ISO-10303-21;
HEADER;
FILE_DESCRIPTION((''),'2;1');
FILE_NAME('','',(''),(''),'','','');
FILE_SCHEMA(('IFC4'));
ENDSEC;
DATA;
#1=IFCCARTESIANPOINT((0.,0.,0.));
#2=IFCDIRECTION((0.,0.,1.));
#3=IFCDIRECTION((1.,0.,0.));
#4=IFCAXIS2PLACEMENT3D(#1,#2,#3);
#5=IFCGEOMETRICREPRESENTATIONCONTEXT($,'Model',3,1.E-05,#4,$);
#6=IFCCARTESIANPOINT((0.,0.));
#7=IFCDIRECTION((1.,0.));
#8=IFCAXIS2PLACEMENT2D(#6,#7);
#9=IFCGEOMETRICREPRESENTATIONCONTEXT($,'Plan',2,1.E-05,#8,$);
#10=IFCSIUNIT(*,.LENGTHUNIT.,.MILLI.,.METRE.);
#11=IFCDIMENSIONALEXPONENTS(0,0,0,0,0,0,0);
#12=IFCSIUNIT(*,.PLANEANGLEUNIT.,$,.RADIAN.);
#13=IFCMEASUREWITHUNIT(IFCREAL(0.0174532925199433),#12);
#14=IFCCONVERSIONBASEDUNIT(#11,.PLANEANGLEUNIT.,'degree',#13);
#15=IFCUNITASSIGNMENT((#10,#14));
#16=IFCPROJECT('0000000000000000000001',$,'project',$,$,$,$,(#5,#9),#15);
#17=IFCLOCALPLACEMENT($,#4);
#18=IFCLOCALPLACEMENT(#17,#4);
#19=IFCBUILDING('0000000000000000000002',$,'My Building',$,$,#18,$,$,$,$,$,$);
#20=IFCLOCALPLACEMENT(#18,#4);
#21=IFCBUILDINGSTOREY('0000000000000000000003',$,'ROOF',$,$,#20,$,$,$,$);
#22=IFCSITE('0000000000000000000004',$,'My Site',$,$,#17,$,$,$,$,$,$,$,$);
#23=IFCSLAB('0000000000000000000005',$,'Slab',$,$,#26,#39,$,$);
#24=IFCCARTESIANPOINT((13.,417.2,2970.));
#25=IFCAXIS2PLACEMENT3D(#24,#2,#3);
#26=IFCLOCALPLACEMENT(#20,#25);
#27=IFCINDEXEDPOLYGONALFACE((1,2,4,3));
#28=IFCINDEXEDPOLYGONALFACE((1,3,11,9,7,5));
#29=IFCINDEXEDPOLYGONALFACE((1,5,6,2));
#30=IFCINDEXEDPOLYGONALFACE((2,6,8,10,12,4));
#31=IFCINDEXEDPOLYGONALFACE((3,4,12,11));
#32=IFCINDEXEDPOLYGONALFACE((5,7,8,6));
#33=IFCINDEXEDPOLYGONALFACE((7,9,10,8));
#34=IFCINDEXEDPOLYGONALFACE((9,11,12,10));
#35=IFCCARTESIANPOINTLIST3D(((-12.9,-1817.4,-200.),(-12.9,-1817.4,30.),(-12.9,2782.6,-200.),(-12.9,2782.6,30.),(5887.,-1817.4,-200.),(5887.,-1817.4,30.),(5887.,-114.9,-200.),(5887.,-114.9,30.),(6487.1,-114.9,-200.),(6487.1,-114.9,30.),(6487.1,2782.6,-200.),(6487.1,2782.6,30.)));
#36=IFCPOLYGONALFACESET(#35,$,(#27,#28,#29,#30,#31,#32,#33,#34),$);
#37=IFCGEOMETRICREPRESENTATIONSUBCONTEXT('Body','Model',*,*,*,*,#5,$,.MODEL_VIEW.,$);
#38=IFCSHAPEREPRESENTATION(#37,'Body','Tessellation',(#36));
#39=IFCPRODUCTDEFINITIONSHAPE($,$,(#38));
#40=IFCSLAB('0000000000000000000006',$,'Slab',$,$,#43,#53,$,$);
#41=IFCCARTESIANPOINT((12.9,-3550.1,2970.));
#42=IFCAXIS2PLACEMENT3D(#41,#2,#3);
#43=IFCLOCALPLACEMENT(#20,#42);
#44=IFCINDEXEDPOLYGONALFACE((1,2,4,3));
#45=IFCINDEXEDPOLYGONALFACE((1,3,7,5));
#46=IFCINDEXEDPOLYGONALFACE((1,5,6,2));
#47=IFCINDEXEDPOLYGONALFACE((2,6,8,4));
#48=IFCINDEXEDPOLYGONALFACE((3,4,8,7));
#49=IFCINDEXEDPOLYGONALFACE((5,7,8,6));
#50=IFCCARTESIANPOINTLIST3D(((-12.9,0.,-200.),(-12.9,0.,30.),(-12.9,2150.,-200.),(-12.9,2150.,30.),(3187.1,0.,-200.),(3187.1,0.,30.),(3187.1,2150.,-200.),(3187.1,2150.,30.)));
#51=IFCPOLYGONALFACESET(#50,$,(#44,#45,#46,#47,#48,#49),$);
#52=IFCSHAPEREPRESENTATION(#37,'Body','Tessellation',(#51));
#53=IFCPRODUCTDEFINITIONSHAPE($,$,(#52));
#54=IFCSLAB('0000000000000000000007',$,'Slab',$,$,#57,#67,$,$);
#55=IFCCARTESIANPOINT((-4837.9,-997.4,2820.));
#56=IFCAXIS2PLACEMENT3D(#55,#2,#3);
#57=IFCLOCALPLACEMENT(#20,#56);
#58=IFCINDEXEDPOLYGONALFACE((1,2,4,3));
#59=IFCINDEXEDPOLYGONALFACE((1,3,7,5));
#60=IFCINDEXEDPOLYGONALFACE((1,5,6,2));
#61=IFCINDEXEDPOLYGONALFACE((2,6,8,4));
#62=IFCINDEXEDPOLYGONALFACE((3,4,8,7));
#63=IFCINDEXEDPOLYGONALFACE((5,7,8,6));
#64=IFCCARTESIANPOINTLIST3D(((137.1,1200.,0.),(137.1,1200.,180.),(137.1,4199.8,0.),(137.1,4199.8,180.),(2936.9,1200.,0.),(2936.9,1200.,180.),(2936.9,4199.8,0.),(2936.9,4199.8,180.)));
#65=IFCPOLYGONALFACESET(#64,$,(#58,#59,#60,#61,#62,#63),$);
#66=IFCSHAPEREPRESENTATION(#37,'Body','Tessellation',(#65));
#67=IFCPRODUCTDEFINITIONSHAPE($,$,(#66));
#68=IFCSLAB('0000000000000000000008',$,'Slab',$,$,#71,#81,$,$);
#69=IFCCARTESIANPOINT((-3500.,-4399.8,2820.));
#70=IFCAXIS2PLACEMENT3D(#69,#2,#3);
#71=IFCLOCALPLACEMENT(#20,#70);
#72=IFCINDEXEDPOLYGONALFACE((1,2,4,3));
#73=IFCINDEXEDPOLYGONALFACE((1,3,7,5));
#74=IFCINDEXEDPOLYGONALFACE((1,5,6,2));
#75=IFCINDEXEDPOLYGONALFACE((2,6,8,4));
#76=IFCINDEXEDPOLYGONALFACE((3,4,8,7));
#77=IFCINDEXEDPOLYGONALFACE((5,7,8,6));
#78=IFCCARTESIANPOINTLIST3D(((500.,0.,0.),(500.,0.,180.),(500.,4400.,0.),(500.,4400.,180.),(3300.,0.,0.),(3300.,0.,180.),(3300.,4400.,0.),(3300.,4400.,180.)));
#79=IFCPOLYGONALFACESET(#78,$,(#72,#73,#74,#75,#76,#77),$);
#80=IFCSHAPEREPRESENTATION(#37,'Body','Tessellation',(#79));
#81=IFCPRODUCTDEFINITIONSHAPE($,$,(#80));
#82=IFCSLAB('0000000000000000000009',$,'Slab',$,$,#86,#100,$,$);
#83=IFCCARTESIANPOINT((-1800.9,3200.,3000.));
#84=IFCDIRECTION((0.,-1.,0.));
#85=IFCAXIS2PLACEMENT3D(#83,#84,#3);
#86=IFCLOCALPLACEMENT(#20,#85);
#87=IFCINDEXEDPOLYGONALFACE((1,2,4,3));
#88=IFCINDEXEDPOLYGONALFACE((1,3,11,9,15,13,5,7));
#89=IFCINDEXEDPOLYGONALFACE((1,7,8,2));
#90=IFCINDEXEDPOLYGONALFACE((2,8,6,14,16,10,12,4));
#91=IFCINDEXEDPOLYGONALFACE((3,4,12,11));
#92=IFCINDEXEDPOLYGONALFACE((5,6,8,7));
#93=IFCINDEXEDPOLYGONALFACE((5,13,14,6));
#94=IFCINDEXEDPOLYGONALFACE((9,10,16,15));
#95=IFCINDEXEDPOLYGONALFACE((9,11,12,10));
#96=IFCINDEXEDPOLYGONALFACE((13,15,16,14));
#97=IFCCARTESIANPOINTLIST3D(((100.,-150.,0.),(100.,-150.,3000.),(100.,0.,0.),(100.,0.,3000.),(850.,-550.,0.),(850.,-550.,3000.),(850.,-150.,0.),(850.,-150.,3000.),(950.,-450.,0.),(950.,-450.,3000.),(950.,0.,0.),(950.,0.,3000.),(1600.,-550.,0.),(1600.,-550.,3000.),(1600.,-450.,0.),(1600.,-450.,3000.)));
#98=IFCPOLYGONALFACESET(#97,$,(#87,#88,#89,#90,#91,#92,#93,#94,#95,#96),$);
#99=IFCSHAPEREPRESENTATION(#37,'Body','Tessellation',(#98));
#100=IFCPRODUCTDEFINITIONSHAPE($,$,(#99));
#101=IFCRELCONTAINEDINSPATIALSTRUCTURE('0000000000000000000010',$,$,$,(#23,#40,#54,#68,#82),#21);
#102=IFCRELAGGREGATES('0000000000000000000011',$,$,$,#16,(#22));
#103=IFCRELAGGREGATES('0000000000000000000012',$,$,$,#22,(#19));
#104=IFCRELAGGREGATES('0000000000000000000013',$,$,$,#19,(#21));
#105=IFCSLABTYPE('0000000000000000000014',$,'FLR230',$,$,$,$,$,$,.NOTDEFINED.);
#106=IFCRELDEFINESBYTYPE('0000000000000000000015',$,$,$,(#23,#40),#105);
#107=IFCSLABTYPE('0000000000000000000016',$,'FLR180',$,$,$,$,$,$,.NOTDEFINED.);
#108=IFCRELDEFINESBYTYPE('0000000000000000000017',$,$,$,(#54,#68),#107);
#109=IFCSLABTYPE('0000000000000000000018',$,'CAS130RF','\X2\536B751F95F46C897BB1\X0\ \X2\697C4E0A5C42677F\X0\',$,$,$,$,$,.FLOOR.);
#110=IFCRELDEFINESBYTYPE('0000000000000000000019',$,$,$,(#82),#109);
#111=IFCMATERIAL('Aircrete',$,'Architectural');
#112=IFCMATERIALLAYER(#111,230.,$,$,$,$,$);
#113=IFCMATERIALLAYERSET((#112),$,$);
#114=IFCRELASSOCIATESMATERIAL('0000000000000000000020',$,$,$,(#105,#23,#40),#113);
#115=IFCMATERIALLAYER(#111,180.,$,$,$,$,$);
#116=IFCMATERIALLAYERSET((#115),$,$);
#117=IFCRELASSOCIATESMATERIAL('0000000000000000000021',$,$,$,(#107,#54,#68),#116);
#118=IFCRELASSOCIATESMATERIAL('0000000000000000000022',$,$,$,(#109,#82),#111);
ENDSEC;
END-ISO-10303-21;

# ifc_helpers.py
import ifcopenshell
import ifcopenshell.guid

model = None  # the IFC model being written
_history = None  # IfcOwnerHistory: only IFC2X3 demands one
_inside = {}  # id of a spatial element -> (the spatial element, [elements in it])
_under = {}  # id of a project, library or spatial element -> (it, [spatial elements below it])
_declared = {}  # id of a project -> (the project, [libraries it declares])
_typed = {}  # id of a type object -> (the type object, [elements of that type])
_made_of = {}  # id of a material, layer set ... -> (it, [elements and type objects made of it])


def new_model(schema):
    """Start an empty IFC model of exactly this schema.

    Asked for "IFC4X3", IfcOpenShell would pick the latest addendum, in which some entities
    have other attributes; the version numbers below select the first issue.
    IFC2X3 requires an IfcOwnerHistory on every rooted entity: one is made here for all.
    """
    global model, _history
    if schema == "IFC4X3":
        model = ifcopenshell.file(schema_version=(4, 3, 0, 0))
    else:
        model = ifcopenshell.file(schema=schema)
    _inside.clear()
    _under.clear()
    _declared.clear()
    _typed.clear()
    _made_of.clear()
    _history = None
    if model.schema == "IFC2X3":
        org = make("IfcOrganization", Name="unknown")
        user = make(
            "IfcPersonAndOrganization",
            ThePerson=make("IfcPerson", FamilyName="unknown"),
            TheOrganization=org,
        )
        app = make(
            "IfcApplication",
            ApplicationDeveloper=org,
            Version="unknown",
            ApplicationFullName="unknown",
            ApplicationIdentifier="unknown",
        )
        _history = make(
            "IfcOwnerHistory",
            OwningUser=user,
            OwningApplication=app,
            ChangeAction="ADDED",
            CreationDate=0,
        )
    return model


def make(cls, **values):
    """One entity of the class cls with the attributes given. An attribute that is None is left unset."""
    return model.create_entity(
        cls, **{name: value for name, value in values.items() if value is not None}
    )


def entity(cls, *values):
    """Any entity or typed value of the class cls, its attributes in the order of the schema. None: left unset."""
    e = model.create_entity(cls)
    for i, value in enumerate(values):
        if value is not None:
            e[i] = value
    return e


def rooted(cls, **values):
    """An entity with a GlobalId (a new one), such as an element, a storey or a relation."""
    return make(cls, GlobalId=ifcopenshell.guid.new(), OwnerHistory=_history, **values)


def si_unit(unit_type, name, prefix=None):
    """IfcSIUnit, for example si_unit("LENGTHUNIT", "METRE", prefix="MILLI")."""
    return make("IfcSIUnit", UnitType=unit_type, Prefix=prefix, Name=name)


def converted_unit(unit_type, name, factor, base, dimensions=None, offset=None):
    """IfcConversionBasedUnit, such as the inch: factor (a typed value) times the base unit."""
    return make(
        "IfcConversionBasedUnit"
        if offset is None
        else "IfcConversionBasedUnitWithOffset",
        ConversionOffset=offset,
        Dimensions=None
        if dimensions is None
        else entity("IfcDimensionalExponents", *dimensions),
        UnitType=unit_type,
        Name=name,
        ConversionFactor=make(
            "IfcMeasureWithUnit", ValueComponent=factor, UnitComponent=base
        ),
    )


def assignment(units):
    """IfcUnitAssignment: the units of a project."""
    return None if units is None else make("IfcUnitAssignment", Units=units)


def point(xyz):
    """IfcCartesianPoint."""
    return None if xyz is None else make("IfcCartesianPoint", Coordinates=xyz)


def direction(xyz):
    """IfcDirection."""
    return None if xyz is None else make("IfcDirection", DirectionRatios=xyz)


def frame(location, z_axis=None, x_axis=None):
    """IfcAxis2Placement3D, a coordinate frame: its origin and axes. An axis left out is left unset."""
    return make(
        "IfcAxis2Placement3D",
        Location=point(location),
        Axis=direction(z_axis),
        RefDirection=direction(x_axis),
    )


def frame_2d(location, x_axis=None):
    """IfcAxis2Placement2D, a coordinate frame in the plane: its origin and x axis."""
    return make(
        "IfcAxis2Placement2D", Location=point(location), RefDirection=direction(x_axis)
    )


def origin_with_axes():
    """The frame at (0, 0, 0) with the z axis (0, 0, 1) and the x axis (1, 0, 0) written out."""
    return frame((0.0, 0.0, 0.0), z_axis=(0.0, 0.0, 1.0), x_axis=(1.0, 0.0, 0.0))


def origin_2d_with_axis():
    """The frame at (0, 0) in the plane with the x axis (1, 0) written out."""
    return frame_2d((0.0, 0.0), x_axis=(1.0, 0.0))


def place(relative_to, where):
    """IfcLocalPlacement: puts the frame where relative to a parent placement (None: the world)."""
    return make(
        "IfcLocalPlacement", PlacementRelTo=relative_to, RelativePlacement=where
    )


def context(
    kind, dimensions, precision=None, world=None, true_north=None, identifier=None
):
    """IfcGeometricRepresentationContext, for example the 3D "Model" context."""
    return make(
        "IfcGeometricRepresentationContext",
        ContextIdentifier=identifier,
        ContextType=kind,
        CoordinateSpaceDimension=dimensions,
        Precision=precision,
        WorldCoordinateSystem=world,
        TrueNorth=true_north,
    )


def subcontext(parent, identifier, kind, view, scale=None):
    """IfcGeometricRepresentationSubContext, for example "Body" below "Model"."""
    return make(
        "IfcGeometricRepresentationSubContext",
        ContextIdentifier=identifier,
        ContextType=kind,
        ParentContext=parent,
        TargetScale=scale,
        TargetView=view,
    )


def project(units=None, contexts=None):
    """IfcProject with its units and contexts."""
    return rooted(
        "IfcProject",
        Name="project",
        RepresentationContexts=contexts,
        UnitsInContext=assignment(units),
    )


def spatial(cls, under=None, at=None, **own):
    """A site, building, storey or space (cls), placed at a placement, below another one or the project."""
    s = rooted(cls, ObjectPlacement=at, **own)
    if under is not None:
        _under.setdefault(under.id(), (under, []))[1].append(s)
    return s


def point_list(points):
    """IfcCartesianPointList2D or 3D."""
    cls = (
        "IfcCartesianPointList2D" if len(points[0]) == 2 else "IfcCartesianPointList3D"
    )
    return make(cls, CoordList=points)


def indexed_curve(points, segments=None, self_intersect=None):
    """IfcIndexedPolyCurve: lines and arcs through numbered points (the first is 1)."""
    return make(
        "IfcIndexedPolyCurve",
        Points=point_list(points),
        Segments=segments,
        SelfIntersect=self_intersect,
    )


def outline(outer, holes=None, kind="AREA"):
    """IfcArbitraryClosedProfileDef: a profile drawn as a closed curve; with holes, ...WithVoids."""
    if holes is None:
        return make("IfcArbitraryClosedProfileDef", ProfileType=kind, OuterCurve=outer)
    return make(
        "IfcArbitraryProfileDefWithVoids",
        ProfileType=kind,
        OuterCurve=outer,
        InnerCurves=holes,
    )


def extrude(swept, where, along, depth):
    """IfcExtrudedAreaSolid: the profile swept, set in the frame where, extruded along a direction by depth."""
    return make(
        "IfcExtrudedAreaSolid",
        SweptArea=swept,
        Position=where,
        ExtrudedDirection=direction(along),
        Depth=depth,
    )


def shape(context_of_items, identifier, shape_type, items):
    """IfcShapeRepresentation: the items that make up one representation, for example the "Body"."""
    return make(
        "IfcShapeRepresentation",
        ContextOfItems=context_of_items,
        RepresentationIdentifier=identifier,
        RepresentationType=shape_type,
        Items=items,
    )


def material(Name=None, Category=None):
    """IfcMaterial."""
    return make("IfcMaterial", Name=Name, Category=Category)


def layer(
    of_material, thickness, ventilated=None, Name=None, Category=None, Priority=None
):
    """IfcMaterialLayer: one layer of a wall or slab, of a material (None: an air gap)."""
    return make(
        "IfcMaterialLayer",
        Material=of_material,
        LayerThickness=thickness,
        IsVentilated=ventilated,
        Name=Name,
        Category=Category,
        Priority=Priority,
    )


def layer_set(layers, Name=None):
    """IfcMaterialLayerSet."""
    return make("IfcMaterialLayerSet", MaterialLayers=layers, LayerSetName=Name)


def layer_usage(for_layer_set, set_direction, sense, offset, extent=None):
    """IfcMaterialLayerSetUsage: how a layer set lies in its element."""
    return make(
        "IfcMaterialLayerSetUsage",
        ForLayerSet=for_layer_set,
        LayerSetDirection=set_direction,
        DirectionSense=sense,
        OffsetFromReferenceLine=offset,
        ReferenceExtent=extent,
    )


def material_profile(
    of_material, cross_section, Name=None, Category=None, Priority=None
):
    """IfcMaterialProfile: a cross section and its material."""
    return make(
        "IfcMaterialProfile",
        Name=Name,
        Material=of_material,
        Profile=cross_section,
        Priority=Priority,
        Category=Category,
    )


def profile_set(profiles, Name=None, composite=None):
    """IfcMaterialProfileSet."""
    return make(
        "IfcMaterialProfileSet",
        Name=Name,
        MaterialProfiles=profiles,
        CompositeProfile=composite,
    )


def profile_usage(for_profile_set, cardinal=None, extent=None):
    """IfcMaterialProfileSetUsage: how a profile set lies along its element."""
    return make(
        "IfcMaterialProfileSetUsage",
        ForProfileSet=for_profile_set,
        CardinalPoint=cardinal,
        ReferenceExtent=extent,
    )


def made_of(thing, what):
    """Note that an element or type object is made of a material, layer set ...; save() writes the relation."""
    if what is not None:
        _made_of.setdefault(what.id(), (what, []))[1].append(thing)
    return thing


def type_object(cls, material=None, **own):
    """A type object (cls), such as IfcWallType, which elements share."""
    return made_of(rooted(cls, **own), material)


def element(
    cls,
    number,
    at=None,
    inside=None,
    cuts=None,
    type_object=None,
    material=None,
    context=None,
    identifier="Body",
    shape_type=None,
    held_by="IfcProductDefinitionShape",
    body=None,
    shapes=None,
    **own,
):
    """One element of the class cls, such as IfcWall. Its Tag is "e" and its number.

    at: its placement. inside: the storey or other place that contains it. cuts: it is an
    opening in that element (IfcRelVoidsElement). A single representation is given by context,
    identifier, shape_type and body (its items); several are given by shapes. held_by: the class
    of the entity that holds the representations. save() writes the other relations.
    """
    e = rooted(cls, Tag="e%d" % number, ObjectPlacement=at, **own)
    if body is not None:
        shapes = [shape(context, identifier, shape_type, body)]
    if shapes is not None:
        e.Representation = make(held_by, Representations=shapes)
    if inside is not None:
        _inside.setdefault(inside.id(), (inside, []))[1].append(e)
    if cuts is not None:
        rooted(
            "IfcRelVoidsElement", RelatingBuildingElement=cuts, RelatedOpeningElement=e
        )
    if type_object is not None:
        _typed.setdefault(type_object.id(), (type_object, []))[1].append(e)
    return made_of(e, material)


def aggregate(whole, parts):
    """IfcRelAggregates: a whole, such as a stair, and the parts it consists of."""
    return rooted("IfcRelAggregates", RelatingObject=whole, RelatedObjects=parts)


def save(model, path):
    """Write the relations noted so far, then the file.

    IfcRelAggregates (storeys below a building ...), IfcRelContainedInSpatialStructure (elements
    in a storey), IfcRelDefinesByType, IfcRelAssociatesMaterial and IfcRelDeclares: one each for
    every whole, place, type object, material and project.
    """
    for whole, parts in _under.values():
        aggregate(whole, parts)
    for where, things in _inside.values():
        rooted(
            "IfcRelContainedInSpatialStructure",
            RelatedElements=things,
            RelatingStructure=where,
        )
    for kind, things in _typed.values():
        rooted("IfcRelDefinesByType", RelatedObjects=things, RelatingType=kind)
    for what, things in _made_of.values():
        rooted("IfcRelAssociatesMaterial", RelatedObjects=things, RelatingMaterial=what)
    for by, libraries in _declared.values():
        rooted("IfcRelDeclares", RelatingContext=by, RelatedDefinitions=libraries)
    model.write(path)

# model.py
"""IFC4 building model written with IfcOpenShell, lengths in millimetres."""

from ifc_helpers import new_model, entity, si_unit, converted_unit, frame, origin_with_axes, origin_2d_with_axis, place, context, subcontext, project, spatial, indexed_curve, outline, extrude, material, layer, layer_set, layer_usage, material_profile, profile_set, profile_usage, type_object, element, save


model = new_model("IFC4")

# Units and contexts
model_context = context("Model", 3, precision=1e-05, world=origin_with_axes())
plan_context = context("Plan", 2, precision=1e-05, world=origin_2d_with_axis())
body_context = subcontext(model_context, "Body", "Model", "MODEL_VIEW")
ifc_project = project(units=[si_unit("LENGTHUNIT", "METRE", prefix="MILLI"), converted_unit("PLANEANGLEUNIT", "degree", entity("IfcReal", 0.0174532925199433), si_unit("PLANEANGLEUNIT", "RADIAN"), dimensions=[0, 0, 0, 0, 0, 0, 0])], contexts=[model_context, plan_context])

# Site, building, storey
site_placement = place(None, origin_with_axes())
site = spatial("IfcSite", under=ifc_project, at=site_placement, Name="My Site")
building_placement = place(site_placement, origin_with_axes())
building = spatial("IfcBuilding", under=site, at=building_placement, Name="My Building")
storey_placement = place(building_placement, origin_with_axes())
storey = spatial("IfcBuildingStorey", under=building, at=storey_placement, Name="ROOF")

# Shared definitions
ifc_material = material(Name="Aircrete", Category="Architectural")

# Slab, opening
ifc_layer_1 = layer(ifc_material, 230.0)
ifc_layer_set_1 = layer_set([ifc_layer_1])
ifc_layer_usage_1 = layer_usage(ifc_layer_set_1, "AXIS3", "POSITIVE", -200.0)
slab_type_1 = type_object("IfcSlabType", Name="FLR230", PredefinedType="NOTDEFINED", material=ifc_layer_set_1)
slab_1_placement = place(storey_placement, frame((13.0, 417.2, 2970.0), z_axis=(0.0, 0.0, 1.0), x_axis=(1.0, 0.0, 0.0)))
slab_1 = element("IfcSlab", 1, at=slab_1_placement, inside=storey, type_object=slab_type_1, material=ifc_layer_usage_1, Name="Slab", context=body_context, shape_type="SweptSolid", body=[
    extrude(outline(indexed_curve([(-12.9, -1817.4), (6487.1, -1817.4), (6487.1, 2782.6), (-12.9, 2782.6), (-12.9, -1817.4)])), frame((0.0, 0.0, -200.0), z_axis=(0.0, 0.0, 1.0), x_axis=(1.0, 0.0, 0.0)), (0.0, 0.0, 1.0), 230.0),
])
opening_1_placement = place(slab_1_placement, frame((6487.1, -1817.4, -200.0), z_axis=(0.0, 0.0, 1.0), x_axis=(0.0, 1.0, 0.0)))
element("IfcOpeningElement", 2, at=opening_1_placement, cuts=slab_1, PredefinedType="OPENING", context=body_context, shape_type="SweptSolid", body=[
    extrude(outline(indexed_curve([(0.0, 600.1), (1702.4, 600.1), (1702.4, 0.0), (0.0, 0.0), (0.0, 600.1)])), origin_with_axes(), (0.0, 0.0, 1.0), 500.0),
])

# Slabs
ifc_layer_usage_2 = layer_usage(ifc_layer_set_1, "AXIS3", "POSITIVE", -200.0)
slab_2_placement = place(storey_placement, frame((12.9, -3550.1, 2970.0), z_axis=(0.0, 0.0, 1.0), x_axis=(1.0, 0.0, 0.0)))
element("IfcSlab", 3, at=slab_2_placement, inside=storey, type_object=slab_type_1, material=ifc_layer_usage_2, Name="Slab", context=body_context, shape_type="SweptSolid", body=[
    extrude(outline(indexed_curve([(-12.9, 2150.0), (3187.1, 2150.0), (3187.1, 0.0), (-12.9, 0.0), (-12.9, 2150.0)])), frame((0.0, 0.0, -200.0), z_axis=(0.0, 0.0, 1.0), x_axis=(1.0, 0.0, 0.0)), (0.0, 0.0, 1.0), 230.0),
])
ifc_layer_2 = layer(ifc_material, 180.0)
ifc_layer_set_2 = layer_set([ifc_layer_2])
slab_type_2 = type_object("IfcSlabType", Name="FLR180", PredefinedType="NOTDEFINED", material=ifc_layer_set_2)
ifc_layer_usage_3 = layer_usage(ifc_layer_set_2, "AXIS3", "POSITIVE", 0.0)
slab_3_placement = place(storey_placement, frame((-4837.9, -997.4, 2820.0), z_axis=(0.0, 0.0, 1.0), x_axis=(1.0, 0.0, 0.0)))
element("IfcSlab", 4, at=slab_3_placement, inside=storey, type_object=slab_type_2, material=ifc_layer_usage_3, Name="Slab", context=body_context, shape_type="SweptSolid", body=[
    extrude(outline(indexed_curve([(137.1, 4199.8), (2936.9, 4199.8), (2936.9, 1200.0), (137.1, 1200.0), (137.1, 4199.8)])), None, (0.0, 0.0, 1.0), 180.0),
])
ifc_layer_usage_4 = layer_usage(ifc_layer_set_2, "AXIS3", "POSITIVE", 0.0)
slab_4_placement = place(storey_placement, frame((-3500.0, -4399.8, 2820.0), z_axis=(0.0, 0.0, 1.0), x_axis=(1.0, 0.0, 0.0)))
element("IfcSlab", 5, at=slab_4_placement, inside=storey, type_object=slab_type_2, material=ifc_layer_usage_4, Name="Slab", context=body_context, shape_type="SweptSolid", body=[
    extrude(outline(indexed_curve([(500.0, 0.0), (3300.0, 0.0), (3300.0, 4400.0), (500.0, 4400.0), (500.0, 0.0)])), None, (0.0, 0.0, 1.0), 180.0),
])

# Slab, opening
ifc_material_profile_1 = material_profile(ifc_material, outline(indexed_curve([(950.0, -450.0), (1600.0, -450.0), (1600.0, -550.0), (850.0, -550.0), (850.0, -150.0), (0.0, -150.0), (0.0, 0.0), (950.0, 0.0), (950.0, -450.0)])))
ifc_profile_set_1 = profile_set([ifc_material_profile_1])
ifc_profile_usage_1 = profile_usage(ifc_profile_set_1)
slab_type_3 = type_object("IfcSlabType", Name="CAS130RF", Description="卫生间沉箱 楼上层板", PredefinedType="FLOOR", material=ifc_profile_set_1)
slab_5_placement = place(storey_placement, frame((-1800.9, 3200.0, 3000.0), z_axis=(0.0, -1.0, 0.0), x_axis=(1.0, 0.0, 0.0)))
slab_5 = element("IfcSlab", 6, at=slab_5_placement, inside=storey, type_object=slab_type_3, material=ifc_profile_usage_1, Name="Slab", context=body_context, shape_type="SweptSolid", body=[
    extrude(outline(indexed_curve([(950.0, -450.0), (1600.0, -450.0), (1600.0, -550.0), (850.0, -550.0), (850.0, -150.0), (0.0, -150.0), (0.0, 0.0), (950.0, 0.0), (950.0, -450.0)])), origin_with_axes(), (0.0, 0.0, 1.0), 3000.0),
])
opening_2_placement = place(slab_5_placement, frame((100.0, -180.0, 0.0), z_axis=(0.0, 1.0, 0.0), x_axis=(-1.0, 0.0, -0.000001)))
element("IfcOpeningElement", 7, at=opening_2_placement, cuts=slab_5, PredefinedType="OPENING", context=body_context, shape_type="SweptSolid", body=[
    extrude(outline(indexed_curve([(0.0, 0.0), (500.0, 0.0), (500.0, 3107.1), (0.0, 3107.1), (0.0, 0.0)])), origin_with_axes(), (0.0, 0.0, 1.0), 500.0),
])

save(model, "model.ifc")
